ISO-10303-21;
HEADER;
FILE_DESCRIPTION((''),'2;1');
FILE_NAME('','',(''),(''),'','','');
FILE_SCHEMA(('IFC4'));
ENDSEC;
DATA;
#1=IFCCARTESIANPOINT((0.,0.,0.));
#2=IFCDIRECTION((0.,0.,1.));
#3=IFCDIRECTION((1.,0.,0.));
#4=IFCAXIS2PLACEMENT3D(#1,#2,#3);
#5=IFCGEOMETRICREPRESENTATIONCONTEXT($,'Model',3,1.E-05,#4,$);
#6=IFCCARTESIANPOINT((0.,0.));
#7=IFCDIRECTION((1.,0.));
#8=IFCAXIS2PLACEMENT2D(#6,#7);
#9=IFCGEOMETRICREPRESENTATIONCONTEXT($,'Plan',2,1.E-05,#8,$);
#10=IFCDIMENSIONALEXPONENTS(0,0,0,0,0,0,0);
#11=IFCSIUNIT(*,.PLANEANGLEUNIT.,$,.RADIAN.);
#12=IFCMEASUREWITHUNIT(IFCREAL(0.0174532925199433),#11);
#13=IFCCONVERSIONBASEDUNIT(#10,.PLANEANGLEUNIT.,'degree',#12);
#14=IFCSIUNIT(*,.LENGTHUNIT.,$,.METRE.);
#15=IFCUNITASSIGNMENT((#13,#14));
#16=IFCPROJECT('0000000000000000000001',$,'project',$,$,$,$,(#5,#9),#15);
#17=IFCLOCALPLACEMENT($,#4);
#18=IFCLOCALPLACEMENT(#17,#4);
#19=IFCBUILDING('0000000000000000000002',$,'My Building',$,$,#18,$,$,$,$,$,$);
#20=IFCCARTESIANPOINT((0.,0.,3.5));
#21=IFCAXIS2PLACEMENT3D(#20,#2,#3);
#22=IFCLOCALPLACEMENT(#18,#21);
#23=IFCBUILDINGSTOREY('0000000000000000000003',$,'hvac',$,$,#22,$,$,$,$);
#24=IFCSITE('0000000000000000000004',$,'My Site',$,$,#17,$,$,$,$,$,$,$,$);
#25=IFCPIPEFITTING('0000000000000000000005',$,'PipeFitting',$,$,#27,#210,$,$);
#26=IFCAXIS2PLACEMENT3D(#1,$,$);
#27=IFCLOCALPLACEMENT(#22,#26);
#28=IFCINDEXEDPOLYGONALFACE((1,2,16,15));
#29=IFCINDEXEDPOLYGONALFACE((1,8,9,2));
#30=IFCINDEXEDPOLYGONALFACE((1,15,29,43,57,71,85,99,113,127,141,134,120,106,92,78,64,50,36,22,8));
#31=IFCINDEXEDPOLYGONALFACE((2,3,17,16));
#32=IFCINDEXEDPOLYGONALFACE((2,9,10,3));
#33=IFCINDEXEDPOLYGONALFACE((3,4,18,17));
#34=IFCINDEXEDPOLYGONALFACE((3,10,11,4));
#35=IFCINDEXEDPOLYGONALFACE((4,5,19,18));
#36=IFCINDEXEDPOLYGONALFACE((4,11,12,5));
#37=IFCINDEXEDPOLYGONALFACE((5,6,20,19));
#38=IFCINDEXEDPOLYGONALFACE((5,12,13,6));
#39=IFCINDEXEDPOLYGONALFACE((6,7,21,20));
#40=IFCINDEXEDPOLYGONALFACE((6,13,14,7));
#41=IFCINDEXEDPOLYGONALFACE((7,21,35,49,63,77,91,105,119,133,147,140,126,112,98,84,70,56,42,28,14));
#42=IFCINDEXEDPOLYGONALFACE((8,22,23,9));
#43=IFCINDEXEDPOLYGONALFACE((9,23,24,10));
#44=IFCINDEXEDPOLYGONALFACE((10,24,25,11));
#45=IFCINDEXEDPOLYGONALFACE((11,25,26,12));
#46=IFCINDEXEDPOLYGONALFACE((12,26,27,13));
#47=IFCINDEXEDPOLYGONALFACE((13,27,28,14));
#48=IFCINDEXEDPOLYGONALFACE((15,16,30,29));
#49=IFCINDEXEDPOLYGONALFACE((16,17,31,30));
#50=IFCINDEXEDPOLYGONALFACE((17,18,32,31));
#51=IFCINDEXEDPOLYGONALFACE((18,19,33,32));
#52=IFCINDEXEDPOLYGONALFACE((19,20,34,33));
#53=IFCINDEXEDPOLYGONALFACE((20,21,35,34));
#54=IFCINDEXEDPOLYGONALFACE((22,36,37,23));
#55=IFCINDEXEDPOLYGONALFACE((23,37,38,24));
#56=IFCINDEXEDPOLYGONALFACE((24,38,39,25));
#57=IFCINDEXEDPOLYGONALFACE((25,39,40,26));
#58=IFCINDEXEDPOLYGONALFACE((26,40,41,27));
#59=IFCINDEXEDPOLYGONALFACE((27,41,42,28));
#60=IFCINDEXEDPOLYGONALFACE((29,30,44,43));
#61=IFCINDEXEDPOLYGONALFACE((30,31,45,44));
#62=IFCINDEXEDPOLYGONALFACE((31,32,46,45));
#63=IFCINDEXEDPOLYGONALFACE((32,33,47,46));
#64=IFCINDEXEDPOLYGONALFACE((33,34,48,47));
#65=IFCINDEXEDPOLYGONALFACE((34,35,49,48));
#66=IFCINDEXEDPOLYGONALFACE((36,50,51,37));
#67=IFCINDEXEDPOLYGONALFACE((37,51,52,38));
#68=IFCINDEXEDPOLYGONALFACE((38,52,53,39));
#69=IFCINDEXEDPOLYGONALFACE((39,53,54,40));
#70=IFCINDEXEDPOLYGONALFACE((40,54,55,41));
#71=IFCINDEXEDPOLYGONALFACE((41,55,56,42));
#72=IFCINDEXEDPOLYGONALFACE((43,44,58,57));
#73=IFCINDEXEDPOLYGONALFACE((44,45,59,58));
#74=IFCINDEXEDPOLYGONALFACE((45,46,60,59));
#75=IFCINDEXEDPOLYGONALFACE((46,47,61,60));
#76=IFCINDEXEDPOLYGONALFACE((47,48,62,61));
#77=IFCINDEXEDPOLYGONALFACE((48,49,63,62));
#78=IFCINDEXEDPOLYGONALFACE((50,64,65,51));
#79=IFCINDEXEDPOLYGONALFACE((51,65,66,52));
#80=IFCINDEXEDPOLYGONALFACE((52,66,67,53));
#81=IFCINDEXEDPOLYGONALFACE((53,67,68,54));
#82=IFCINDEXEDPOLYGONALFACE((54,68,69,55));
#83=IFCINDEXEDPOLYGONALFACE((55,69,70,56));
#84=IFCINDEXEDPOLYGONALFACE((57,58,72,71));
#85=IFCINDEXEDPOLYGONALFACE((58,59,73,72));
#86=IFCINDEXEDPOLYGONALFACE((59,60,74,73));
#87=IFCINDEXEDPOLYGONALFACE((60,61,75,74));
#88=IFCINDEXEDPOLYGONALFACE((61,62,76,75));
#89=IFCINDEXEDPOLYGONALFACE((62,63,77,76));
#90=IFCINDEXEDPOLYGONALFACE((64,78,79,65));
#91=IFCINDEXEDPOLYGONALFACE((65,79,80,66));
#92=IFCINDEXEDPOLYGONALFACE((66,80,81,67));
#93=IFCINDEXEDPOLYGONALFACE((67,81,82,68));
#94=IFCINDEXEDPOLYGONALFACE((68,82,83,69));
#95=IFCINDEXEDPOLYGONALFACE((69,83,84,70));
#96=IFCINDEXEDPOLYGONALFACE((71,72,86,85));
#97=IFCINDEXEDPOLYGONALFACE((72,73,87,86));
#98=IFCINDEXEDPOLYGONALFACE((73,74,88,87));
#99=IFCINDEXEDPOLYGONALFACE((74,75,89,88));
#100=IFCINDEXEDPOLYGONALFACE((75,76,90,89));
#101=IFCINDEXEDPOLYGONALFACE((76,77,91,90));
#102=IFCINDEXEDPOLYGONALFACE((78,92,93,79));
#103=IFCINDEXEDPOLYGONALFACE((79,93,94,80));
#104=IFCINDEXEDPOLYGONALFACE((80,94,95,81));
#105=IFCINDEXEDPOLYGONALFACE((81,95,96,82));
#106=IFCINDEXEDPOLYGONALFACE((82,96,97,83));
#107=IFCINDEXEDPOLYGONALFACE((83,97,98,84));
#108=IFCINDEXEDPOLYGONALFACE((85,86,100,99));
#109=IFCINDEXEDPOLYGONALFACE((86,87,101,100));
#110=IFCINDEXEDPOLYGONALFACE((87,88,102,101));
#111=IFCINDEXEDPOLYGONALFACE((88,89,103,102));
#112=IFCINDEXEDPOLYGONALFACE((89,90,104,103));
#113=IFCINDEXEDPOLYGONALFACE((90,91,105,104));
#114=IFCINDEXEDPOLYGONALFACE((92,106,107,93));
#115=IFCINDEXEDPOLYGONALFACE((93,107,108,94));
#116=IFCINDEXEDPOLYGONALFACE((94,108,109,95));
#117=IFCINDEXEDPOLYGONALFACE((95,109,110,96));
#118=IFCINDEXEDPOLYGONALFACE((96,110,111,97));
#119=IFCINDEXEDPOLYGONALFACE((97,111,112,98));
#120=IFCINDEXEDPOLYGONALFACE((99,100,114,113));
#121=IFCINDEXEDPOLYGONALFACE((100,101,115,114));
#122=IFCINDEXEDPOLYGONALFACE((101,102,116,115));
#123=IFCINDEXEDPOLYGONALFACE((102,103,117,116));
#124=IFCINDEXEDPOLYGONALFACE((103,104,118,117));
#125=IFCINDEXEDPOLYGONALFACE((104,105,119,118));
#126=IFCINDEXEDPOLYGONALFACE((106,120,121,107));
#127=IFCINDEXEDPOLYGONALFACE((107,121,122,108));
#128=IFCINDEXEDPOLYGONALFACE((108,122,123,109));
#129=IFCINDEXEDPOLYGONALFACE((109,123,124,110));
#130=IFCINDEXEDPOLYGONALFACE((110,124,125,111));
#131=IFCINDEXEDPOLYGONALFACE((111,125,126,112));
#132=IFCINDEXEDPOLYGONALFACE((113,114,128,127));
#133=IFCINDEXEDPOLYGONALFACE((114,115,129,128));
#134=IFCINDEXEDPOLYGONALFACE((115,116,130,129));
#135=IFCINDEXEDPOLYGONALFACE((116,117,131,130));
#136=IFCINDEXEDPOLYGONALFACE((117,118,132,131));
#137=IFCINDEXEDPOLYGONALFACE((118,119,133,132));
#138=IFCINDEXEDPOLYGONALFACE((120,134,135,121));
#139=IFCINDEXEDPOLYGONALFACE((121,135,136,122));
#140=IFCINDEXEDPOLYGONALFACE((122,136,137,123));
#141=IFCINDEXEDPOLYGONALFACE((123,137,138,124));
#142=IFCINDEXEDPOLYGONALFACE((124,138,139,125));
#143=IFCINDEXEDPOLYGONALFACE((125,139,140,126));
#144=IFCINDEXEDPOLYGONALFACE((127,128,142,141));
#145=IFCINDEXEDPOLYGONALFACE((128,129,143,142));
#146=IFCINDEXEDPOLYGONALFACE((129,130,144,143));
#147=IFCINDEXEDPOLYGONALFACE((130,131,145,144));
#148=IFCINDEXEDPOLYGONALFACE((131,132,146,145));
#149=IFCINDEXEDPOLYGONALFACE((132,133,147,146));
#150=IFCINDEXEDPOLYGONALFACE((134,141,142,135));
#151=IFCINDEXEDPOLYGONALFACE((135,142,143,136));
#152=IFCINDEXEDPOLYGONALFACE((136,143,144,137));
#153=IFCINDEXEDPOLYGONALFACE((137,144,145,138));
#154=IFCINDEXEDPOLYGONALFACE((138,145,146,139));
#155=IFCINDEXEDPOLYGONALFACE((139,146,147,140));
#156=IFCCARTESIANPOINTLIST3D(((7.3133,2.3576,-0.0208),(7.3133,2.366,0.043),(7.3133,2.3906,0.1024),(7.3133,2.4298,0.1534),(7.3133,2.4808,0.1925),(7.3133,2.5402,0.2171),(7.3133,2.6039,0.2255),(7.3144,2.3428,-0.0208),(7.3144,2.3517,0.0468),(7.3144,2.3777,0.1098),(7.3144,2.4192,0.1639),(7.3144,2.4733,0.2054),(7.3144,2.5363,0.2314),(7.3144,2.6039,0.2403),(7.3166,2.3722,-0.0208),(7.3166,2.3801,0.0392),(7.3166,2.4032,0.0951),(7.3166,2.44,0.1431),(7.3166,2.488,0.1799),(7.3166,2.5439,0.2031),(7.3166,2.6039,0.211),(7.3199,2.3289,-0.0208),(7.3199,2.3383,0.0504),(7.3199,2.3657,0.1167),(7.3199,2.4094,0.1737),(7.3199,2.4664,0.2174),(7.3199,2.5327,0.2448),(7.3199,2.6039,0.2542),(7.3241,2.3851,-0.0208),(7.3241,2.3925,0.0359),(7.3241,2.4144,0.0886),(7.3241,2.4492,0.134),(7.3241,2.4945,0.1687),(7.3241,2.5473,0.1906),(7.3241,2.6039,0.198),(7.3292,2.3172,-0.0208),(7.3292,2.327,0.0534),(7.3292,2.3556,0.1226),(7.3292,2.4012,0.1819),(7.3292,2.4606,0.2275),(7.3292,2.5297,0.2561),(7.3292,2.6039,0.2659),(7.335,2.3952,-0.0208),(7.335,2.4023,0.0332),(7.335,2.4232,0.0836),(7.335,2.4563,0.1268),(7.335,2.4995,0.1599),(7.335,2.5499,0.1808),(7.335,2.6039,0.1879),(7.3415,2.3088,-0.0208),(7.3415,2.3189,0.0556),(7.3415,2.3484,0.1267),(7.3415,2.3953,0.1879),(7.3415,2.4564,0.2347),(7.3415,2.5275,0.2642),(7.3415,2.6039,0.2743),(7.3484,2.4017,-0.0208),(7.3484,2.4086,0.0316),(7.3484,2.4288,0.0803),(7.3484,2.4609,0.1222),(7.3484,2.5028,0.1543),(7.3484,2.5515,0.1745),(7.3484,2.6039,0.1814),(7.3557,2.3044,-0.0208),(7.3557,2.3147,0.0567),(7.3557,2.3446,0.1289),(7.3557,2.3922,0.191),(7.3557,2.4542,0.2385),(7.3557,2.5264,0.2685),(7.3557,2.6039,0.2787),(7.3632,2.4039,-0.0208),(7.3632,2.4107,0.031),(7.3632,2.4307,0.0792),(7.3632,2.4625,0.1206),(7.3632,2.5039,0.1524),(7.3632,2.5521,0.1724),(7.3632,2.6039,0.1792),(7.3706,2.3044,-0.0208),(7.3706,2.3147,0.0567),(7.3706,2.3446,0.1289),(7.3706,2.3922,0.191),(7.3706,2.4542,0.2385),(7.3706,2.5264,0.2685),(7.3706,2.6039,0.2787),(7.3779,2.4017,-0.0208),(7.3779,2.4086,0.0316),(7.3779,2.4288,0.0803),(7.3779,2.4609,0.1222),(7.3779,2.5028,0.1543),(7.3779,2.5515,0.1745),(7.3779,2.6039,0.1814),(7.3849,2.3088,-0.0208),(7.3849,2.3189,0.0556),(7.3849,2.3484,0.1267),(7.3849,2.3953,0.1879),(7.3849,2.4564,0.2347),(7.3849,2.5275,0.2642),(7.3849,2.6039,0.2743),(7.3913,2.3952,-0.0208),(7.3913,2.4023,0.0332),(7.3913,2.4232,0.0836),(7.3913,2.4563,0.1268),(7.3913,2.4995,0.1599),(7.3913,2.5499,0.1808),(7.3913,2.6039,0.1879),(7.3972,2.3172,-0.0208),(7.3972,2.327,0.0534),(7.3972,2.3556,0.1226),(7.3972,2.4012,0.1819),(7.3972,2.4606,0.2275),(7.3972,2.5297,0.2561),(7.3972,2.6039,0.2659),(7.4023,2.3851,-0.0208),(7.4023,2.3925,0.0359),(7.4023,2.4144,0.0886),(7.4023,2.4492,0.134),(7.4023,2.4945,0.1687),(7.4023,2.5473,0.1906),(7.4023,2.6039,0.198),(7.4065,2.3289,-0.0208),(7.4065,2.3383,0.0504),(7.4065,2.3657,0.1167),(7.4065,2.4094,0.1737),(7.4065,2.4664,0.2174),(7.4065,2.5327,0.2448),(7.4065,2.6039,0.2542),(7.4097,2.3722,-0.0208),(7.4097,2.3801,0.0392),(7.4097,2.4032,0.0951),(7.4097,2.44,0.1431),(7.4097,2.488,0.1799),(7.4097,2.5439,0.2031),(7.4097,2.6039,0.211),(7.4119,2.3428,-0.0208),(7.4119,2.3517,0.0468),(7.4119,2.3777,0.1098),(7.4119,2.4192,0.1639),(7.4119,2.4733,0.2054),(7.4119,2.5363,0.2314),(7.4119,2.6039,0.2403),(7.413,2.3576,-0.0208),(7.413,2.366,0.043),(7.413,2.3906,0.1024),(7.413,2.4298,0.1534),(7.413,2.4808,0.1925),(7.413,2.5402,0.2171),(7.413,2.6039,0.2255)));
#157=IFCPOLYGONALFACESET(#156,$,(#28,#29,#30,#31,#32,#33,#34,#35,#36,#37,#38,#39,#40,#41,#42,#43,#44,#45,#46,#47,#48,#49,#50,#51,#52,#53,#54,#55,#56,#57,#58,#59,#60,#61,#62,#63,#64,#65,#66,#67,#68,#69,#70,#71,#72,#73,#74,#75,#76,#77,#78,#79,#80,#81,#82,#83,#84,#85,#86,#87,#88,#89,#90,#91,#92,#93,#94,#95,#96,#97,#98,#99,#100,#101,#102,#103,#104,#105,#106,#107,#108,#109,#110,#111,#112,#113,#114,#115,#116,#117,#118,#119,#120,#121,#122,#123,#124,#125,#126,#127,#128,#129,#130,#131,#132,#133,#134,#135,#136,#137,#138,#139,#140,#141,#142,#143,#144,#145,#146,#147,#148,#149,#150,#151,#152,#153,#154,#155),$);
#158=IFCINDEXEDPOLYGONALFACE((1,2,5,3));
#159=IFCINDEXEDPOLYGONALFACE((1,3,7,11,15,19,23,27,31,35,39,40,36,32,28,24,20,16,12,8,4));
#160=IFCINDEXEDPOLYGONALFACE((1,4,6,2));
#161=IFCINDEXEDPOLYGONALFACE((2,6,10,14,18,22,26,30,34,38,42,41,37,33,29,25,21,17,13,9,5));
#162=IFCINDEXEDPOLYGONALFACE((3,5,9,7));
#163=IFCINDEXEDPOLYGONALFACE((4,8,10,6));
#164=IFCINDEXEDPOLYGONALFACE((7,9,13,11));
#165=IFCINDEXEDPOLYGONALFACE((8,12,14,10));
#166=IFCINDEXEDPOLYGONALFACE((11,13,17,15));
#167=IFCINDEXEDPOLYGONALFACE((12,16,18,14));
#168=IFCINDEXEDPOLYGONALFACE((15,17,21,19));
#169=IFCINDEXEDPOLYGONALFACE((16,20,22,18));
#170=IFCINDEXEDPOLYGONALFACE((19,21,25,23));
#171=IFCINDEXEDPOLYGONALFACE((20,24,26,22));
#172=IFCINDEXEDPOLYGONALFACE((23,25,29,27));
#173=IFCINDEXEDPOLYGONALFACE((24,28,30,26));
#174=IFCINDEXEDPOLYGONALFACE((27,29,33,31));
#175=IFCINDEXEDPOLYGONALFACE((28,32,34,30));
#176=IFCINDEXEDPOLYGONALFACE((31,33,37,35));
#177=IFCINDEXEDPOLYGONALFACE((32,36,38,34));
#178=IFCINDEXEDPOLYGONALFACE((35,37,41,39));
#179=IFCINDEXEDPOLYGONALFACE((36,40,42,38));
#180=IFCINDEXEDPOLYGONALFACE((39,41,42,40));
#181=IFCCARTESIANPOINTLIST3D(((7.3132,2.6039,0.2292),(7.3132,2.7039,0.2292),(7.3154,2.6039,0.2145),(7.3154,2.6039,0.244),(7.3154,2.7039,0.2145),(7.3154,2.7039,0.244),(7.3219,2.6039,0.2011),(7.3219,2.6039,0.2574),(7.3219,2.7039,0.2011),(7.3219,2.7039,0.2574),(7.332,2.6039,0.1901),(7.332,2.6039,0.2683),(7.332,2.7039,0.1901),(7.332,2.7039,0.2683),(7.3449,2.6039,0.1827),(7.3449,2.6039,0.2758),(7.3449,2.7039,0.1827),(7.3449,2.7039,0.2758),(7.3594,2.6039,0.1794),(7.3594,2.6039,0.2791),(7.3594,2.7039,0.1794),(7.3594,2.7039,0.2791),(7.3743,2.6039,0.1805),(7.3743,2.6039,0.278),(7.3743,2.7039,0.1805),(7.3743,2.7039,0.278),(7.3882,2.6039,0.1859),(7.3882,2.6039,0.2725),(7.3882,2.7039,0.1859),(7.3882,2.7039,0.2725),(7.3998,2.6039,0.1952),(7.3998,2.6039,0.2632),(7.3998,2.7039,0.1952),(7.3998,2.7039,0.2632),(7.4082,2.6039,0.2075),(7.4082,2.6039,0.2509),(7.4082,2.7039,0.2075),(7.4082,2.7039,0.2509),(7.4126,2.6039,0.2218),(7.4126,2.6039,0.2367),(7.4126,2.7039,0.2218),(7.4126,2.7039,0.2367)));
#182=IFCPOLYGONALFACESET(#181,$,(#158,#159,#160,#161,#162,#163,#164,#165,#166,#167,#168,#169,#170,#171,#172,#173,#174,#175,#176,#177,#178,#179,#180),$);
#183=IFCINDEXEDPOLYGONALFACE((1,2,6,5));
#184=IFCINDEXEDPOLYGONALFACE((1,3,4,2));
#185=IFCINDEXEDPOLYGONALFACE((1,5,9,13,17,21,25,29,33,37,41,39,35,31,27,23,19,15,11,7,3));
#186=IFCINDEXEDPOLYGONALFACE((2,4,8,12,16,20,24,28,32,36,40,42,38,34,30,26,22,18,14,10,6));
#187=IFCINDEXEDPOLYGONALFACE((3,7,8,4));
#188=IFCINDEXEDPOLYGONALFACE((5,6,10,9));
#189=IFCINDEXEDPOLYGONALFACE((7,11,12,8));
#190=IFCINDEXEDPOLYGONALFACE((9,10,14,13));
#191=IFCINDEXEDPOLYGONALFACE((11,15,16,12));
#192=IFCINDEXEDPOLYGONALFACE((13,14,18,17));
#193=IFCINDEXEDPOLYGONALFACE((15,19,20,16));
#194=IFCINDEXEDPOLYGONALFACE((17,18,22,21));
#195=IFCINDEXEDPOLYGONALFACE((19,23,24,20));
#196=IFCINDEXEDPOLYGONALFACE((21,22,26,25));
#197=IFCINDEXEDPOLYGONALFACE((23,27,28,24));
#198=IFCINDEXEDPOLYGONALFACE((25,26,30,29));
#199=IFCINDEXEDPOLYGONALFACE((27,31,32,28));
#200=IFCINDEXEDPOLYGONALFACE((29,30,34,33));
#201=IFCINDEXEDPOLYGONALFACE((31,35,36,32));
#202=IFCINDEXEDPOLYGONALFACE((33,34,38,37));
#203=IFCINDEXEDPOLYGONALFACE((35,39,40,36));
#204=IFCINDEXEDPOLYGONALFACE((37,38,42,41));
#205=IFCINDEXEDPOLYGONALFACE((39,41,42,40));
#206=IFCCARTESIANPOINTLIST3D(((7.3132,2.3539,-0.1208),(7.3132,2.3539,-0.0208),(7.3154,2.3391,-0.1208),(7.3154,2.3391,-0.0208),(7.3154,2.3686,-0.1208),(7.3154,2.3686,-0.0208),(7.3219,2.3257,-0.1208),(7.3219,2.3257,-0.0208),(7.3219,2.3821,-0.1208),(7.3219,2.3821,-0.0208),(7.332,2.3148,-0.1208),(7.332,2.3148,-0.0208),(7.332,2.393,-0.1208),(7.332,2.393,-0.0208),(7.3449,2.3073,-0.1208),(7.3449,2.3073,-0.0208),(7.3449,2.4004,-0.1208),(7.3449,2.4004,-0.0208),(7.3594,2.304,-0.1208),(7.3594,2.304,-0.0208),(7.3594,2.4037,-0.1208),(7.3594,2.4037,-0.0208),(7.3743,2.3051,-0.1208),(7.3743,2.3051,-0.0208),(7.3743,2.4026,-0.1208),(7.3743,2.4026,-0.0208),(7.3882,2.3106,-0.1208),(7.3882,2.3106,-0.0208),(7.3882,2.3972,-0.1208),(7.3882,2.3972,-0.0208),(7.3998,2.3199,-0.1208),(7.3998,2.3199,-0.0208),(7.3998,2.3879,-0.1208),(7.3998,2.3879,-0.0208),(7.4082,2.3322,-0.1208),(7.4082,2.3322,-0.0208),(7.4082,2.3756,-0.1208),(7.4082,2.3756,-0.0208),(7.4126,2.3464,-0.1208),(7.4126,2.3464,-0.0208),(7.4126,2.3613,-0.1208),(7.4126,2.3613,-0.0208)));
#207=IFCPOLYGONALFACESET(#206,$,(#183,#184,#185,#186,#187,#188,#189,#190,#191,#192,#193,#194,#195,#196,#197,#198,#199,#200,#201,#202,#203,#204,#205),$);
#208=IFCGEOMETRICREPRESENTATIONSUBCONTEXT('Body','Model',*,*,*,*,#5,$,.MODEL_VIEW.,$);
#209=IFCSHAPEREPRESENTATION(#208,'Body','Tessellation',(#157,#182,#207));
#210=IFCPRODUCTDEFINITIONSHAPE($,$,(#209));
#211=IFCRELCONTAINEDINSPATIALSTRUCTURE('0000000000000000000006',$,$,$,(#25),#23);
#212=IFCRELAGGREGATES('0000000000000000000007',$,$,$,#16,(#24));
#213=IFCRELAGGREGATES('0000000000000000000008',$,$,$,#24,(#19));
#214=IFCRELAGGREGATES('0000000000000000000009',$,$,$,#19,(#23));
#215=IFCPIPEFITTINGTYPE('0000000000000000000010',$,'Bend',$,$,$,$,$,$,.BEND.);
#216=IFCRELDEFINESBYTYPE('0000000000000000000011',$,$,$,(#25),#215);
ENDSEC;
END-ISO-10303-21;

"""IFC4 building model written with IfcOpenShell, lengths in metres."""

from ifc_helpers import new_model, entity, si_unit, converted_unit, frame, origin_with_axes, origin_2d_with_axis, place, context, subcontext, project, spatial, circle, extrude, source, transform, mapped, type_object, type_shapes, element, save


model = new_model("IFC4")

# Units and contexts
model_context = context("Model", 3, precision=1e-05, world=origin_with_axes())
plan_context = context("Plan", 2, precision=1e-05, world=origin_2d_with_axis())
body_context_1 = subcontext(model_context, "Body", "Model", "MODEL_VIEW")
ifc_project = project(units=[converted_unit("PLANEANGLEUNIT", "degree", entity("IfcReal", 0.0174532925199433), si_unit("PLANEANGLEUNIT", "RADIAN"), dimensions=[0, 0, 0, 0, 0, 0, 0]), si_unit("LENGTHUNIT", "METRE")], contexts=[model_context, plan_context])

# Site, building, storey
site_placement = place(None, origin_with_axes())
site = spatial("IfcSite", under=ifc_project, at=site_placement, Name="My Site")
building_placement = place(site_placement, origin_with_axes())
building = spatial("IfcBuilding", under=site, at=building_placement, Name="My Building")
storey_placement = place(building_placement, frame((0.0, 0.0, 3.5), z_axis=(0.0, 0.0, 1.0), x_axis=(1.0, 0.0, 0.0)))
storey = spatial("IfcBuildingStorey", under=building, at=storey_placement, Name="hvac")

# Pipe fitting
pipe_fitting_type = type_object("IfcPipeFittingType", Name="Bend", PredefinedType="BEND")
shared_shape_1 = source(origin_with_axes(), body_context_1, "Body", "SolidModel", [
    entity("IfcSweptDiskSolid", entity("IfcIndexedPolyCurve", entity("IfcCartesianPointList3D", [[0.0, 0.0, -0.1], [0.0, -0.0732, -0.2768], [0.0, -0.25, -0.35]]), [entity("IfcArcIndex", [1, 2, 3])]), 0.05),
    extrude(circle(Radius=0.05), origin_with_axes(), (0.0, 0.0, -1.0), 0.1),
    extrude(circle(Radius=0.05), frame((0.0, -0.25, -0.35), z_axis=(0.0, -1.0, -0.000032), x_axis=(1.0, 0.0, 0.0)), (0.0, 0.0, 1.0), 0.1),
])
type_shapes(pipe_fitting_type, [shared_shape_1])
for number, where, z_axis, x_axis, name in (
    (1, (7.3632, 2.7039, 0.2292), (0.0, 1.0, 0.0), (-1.0, 0.0, 0.0), "PipeFitting"),
):
    element("IfcPipeFitting", number, at=place(storey_placement, frame(where, z_axis=z_axis, x_axis=x_axis)), inside=storey, type_object=pipe_fitting_type, Name=name, context=body_context_1, shape_type="MappedRepresentation", body=[
        mapped(shared_shape_1, transform((0.0, 0.0, 0.0), x_axis=(1.0, 0.0, 0.0), y_axis=(0.0, 1.0, 0.0), z_axis=(0.0, 0.0, 1.0), scale=1.0)),
    ])

save(model, "model.ifc")
